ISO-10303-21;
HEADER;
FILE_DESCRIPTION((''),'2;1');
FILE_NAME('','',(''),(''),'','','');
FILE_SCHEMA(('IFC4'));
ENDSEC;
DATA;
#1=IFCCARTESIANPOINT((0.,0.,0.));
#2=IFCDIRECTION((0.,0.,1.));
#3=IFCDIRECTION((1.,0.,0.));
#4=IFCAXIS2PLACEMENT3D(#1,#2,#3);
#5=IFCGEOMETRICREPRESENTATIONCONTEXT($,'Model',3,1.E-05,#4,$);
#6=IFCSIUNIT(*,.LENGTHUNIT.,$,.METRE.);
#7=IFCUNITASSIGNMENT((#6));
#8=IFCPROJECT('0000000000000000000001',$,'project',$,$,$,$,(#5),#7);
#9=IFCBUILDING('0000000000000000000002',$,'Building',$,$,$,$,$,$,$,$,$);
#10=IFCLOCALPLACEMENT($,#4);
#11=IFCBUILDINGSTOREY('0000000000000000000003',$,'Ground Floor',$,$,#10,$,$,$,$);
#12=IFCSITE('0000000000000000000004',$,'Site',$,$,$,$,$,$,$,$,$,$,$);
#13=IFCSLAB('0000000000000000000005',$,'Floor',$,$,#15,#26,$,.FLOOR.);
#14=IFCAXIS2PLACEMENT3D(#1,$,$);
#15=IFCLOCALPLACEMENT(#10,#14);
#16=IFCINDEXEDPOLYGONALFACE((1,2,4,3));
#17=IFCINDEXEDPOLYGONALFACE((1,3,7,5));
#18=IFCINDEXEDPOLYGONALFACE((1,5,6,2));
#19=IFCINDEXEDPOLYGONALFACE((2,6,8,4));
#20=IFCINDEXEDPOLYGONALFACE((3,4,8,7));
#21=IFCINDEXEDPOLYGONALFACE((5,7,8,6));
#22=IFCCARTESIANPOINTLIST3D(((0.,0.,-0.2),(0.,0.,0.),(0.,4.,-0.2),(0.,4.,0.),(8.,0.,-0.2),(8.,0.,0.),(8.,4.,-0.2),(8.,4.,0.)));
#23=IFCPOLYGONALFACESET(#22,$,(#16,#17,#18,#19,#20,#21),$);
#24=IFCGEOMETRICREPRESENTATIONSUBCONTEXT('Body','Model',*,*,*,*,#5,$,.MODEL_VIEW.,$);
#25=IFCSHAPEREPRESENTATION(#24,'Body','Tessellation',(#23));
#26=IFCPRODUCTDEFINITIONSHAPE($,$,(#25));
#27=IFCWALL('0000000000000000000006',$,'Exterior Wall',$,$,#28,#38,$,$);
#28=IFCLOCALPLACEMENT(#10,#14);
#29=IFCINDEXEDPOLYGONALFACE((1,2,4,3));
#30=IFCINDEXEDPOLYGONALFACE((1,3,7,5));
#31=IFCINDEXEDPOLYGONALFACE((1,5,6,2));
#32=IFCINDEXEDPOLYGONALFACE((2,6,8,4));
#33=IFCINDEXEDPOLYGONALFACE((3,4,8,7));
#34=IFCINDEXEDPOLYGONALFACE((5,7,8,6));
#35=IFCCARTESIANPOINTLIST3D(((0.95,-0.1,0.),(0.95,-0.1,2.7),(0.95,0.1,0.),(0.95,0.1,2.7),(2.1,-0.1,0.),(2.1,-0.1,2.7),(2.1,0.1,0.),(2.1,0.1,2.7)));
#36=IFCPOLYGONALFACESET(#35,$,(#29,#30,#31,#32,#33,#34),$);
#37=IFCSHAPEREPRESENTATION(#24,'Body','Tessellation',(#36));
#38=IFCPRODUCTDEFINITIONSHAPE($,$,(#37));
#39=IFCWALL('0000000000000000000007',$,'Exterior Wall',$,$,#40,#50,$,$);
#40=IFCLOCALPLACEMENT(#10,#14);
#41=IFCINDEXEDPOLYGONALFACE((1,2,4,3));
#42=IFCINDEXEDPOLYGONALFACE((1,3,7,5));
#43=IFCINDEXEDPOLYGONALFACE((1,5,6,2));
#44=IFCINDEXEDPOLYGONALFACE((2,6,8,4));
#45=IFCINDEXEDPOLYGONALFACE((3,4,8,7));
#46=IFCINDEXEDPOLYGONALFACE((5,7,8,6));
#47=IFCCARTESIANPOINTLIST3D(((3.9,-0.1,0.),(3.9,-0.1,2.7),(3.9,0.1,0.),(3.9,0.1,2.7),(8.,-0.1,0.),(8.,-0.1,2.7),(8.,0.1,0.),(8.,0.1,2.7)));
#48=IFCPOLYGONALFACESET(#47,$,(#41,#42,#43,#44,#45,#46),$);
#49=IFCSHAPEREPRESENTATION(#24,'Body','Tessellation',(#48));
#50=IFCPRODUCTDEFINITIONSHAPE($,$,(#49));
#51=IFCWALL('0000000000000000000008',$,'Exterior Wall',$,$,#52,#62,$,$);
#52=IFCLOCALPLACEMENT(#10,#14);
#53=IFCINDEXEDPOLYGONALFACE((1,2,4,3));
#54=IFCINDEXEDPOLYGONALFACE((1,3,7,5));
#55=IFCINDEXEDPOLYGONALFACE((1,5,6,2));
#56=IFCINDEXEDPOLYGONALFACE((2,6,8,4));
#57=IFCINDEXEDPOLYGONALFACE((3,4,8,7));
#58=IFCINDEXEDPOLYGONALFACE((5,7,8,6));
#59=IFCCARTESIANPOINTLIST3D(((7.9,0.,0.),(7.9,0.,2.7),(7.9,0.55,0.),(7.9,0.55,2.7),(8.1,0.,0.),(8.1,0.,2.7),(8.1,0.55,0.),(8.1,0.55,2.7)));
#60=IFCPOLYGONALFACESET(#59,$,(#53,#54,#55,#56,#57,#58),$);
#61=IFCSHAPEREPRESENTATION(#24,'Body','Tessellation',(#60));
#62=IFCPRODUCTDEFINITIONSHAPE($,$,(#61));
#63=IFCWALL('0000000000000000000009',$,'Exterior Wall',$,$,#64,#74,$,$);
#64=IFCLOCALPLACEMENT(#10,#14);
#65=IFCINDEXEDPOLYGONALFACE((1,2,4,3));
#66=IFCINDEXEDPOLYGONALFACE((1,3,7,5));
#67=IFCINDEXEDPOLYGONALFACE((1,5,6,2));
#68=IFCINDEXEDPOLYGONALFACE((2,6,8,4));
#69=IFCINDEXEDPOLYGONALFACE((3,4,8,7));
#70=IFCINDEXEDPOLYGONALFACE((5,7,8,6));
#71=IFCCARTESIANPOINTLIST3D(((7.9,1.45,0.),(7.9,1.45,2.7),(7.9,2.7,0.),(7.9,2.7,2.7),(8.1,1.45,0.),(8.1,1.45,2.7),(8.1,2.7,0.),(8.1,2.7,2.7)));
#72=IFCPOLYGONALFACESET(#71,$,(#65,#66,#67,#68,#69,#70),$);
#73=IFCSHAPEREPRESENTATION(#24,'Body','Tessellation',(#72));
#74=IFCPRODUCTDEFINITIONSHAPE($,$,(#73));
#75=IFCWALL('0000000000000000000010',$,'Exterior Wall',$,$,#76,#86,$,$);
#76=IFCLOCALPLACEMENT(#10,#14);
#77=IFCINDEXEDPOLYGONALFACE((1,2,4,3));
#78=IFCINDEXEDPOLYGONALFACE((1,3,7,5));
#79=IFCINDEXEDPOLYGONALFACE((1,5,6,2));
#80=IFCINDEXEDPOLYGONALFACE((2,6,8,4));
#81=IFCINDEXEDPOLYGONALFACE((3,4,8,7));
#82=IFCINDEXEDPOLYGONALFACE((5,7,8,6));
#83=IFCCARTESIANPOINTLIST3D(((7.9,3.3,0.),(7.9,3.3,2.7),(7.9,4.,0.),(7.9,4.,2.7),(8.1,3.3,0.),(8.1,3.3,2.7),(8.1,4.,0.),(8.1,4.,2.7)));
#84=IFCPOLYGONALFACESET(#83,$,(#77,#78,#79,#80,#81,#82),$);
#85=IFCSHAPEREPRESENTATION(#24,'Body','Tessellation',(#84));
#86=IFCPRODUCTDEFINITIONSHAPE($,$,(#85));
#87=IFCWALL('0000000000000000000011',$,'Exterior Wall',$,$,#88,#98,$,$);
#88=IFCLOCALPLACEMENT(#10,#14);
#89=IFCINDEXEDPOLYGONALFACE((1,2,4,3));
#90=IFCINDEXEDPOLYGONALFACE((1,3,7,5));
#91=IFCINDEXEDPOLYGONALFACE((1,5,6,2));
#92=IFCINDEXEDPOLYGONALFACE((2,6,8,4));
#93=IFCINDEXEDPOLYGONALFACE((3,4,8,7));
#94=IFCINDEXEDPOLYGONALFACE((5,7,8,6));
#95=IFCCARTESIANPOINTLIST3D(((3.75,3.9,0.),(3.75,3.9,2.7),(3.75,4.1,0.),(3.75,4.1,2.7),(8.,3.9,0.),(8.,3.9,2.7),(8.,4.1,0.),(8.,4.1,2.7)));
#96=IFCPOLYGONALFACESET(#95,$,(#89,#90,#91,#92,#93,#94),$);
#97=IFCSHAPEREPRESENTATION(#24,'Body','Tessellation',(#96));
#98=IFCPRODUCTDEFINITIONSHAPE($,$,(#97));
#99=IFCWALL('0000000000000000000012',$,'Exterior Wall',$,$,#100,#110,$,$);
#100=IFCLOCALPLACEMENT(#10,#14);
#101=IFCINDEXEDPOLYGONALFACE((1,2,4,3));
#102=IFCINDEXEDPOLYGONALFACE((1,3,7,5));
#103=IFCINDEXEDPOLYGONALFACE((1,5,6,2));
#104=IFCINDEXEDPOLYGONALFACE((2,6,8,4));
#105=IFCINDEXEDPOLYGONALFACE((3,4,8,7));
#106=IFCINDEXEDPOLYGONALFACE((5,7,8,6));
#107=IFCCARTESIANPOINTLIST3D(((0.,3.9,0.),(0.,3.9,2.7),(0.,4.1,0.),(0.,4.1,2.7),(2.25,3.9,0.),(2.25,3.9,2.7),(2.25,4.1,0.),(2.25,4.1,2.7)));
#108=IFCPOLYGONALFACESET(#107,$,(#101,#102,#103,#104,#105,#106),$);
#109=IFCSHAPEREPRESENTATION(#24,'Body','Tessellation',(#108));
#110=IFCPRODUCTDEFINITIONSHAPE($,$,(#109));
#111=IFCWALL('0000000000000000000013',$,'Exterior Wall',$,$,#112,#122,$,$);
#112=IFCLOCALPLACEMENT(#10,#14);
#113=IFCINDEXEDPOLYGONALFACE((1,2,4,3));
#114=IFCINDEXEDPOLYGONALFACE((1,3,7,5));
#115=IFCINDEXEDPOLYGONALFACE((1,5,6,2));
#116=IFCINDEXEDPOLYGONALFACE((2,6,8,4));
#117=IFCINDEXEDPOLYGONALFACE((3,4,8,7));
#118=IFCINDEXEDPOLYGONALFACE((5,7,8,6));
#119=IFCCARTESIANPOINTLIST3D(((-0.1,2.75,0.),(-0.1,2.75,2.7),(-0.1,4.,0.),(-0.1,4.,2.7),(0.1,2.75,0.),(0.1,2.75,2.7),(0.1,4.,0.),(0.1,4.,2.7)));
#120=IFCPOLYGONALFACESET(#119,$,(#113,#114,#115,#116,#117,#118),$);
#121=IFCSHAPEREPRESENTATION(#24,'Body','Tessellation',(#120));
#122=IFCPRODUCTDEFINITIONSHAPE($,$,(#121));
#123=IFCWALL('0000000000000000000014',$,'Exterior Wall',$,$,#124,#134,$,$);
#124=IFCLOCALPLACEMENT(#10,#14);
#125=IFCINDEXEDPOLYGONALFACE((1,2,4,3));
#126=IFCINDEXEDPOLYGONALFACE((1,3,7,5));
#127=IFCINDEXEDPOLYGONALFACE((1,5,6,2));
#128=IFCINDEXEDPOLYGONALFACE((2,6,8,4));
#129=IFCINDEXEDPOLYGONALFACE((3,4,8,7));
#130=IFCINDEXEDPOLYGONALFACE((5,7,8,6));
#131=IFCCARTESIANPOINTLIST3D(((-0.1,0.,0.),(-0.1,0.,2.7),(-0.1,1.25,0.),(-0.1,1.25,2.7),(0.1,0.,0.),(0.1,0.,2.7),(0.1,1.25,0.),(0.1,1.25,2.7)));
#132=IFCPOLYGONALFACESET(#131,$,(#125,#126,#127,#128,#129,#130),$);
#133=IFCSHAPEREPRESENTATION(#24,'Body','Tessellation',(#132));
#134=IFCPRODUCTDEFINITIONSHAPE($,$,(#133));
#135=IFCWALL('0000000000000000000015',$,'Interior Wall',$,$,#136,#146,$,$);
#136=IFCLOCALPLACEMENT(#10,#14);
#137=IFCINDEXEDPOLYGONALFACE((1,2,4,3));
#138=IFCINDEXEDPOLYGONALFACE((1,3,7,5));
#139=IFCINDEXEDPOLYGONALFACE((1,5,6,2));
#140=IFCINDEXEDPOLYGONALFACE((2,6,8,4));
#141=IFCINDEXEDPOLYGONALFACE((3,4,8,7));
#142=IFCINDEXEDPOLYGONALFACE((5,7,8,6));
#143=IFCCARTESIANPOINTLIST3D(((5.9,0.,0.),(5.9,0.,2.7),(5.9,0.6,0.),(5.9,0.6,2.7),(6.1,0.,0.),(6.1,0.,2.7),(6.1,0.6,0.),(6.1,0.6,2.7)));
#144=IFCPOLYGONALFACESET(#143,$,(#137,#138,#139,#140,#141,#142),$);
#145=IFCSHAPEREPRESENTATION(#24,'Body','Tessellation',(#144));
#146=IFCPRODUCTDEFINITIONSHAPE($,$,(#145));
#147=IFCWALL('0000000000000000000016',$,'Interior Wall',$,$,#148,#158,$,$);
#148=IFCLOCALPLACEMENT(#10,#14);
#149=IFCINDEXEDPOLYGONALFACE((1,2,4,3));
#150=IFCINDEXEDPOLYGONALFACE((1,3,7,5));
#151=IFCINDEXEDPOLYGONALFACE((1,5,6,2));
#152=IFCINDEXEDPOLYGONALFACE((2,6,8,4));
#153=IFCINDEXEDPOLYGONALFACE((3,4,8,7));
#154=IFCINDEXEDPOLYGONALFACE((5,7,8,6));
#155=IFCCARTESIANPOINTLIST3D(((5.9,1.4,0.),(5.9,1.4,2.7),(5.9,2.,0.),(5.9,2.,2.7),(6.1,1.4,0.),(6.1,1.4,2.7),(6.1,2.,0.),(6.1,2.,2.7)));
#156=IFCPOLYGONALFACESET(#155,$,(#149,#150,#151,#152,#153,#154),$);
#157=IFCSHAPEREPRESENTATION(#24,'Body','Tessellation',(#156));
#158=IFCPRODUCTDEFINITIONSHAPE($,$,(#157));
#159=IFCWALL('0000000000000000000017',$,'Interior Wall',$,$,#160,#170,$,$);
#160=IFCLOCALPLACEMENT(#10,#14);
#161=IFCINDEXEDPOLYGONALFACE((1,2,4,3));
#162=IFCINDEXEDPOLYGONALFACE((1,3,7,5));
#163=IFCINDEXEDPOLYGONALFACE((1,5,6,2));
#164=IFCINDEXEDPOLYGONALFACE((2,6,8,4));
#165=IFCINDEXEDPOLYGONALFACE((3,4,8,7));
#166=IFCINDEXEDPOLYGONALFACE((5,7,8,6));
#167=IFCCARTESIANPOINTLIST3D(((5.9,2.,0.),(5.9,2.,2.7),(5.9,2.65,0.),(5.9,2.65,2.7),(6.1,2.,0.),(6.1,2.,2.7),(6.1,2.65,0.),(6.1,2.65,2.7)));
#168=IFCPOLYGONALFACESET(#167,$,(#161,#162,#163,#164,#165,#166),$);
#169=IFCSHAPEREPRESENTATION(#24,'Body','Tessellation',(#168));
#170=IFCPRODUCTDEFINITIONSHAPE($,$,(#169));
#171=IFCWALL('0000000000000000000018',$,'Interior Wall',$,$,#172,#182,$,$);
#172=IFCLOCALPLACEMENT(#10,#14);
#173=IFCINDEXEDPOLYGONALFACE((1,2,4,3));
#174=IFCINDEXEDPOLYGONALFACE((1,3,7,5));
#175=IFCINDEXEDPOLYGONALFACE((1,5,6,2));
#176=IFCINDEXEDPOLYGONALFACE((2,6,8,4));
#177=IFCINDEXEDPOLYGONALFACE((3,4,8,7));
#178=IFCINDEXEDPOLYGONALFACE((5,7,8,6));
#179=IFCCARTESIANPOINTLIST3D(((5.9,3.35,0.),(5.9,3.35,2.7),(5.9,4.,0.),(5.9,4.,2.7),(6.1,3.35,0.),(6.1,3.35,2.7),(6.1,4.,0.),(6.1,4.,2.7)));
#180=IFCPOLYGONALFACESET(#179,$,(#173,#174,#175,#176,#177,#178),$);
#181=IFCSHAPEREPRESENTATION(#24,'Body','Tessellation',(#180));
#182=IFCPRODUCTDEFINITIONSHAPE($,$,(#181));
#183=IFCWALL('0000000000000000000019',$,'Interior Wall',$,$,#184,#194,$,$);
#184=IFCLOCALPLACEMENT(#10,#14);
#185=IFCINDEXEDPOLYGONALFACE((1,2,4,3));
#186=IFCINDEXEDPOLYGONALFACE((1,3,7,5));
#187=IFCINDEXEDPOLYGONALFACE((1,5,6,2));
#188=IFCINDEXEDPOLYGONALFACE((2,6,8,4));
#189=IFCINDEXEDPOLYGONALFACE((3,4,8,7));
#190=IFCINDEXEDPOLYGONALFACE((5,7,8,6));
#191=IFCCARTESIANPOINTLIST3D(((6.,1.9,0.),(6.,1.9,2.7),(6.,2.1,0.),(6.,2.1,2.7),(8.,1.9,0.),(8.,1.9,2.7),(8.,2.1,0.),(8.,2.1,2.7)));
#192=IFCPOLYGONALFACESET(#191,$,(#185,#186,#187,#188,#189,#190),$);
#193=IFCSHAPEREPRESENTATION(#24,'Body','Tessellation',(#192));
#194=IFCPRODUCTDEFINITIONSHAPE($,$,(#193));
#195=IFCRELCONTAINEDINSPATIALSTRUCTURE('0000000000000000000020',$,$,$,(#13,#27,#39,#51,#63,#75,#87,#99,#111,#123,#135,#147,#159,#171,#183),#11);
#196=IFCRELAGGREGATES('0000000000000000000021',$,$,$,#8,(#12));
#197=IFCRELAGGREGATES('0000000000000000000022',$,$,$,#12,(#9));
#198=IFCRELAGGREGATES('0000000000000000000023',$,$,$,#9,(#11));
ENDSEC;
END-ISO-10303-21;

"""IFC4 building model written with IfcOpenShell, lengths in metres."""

from ifc_helpers import new_model, si_unit, frame, origin_with_axes, place, context, subcontext, project, spatial, indexed_curve, outline, extrude, element, save


model = new_model("IFC4")

# Units and contexts
model_context = context("Model", 3, precision=1e-05, world=origin_with_axes())
body_context = subcontext(model_context, "Body", "Model", "MODEL_VIEW")
ifc_project = project(units=[si_unit("LENGTHUNIT", "METRE")], contexts=[model_context])

# Site, building, storey
site = spatial("IfcSite", under=ifc_project, Name="Site")
building = spatial("IfcBuilding", under=site, Name="Building")
storey_placement = place(None, origin_with_axes())
storey = spatial("IfcBuildingStorey", under=building, at=storey_placement, Name="Ground Floor")

# Slab
slab_placement = place(storey_placement, frame((0.0, 0.0, -0.2), z_axis=(0.0, 0.0, 1.0), x_axis=(1.0, 0.0, 0.0)))
element("IfcSlab", 1, at=slab_placement, inside=storey, Name="Floor", PredefinedType="FLOOR", context=body_context, shape_type="SweptSolid", body=[
    extrude(outline(indexed_curve([(0.0, 0.0), (8.0, 0.0), (8.0, 4.0), (0.0, 4.0)])), None, (0.0, 0.0, 1.0), 0.2),
])

# Walls
wall_1_placement = place(storey_placement, frame((0.95, 0.0, 0.0), z_axis=(0.0, 0.0, 1.0), x_axis=(1.0, 0.0, 0.0)))
element("IfcWall", 2, at=wall_1_placement, inside=storey, Name="Exterior Wall", context=body_context, shape_type="SweptSolid", body=[
    extrude(outline(indexed_curve([(0.0, 0.0), (0.0, 0.2), (1.15, 0.2), (1.15, 0.0), (0.0, 0.0)], self_intersect=False)), frame((0.0, -0.1, 0.0), z_axis=(0.0, 0.0, 1.0), x_axis=(1.0, 0.0, 0.0)), (0.0, 0.0, 1.0), 2.7),
])
wall_2_placement = place(storey_placement, frame((3.9, 0.0, 0.0), z_axis=(0.0, 0.0, 1.0), x_axis=(1.0, 0.0, 0.0)))
element("IfcWall", 3, at=wall_2_placement, inside=storey, Name="Exterior Wall", context=body_context, shape_type="SweptSolid", body=[
    extrude(outline(indexed_curve([(0.0, 0.0), (0.0, 0.2), (4.1, 0.2), (4.1, 0.0), (0.0, 0.0)], self_intersect=False)), frame((0.0, -0.1, 0.0), z_axis=(0.0, 0.0, 1.0), x_axis=(1.0, 0.0, 0.0)), (0.0, 0.0, 1.0), 2.7),
])
wall_3_placement = place(storey_placement, frame((8.0, 0.0, 0.0), z_axis=(0.0, 0.0, 1.0), x_axis=(0.0, 1.0, 0.0)))
element("IfcWall", 4, at=wall_3_placement, inside=storey, Name="Exterior Wall", context=body_context, shape_type="SweptSolid", body=[
    extrude(outline(indexed_curve([(0.0, 0.0), (0.0, 0.2), (0.55, 0.2), (0.55, 0.0), (0.0, 0.0)], self_intersect=False)), frame((0.0, -0.1, 0.0), z_axis=(0.0, 0.0, 1.0), x_axis=(1.0, 0.0, 0.0)), (0.0, 0.0, 1.0), 2.7),
])
wall_4_placement = place(storey_placement, frame((8.0, 1.45, 0.0), z_axis=(0.0, 0.0, 1.0), x_axis=(0.0, 1.0, 0.0)))
element("IfcWall", 5, at=wall_4_placement, inside=storey, Name="Exterior Wall", context=body_context, shape_type="SweptSolid", body=[
    extrude(outline(indexed_curve([(0.0, 0.0), (0.0, 0.2), (1.25, 0.2), (1.25, 0.0), (0.0, 0.0)], self_intersect=False)), frame((0.0, -0.1, 0.0), z_axis=(0.0, 0.0, 1.0), x_axis=(1.0, 0.0, 0.0)), (0.0, 0.0, 1.0), 2.7),
])
wall_5_placement = place(storey_placement, frame((8.0, 3.3, 0.0), z_axis=(0.0, 0.0, 1.0), x_axis=(0.0, 1.0, 0.0)))
element("IfcWall", 6, at=wall_5_placement, inside=storey, Name="Exterior Wall", context=body_context, shape_type="SweptSolid", body=[
    extrude(outline(indexed_curve([(0.0, 0.0), (0.0, 0.2), (0.7, 0.2), (0.7, 0.0), (0.0, 0.0)], self_intersect=False)), frame((0.0, -0.1, 0.0), z_axis=(0.0, 0.0, 1.0), x_axis=(1.0, 0.0, 0.0)), (0.0, 0.0, 1.0), 2.7),
])
wall_6_placement = place(storey_placement, frame((8.0, 4.0, 0.0), z_axis=(0.0, 0.0, 1.0), x_axis=(-1.0, 0.0, 0.0)))
element("IfcWall", 7, at=wall_6_placement, inside=storey, Name="Exterior Wall", context=body_context, shape_type="SweptSolid", body=[
    extrude(outline(indexed_curve([(0.0, 0.0), (0.0, 0.2), (4.25, 0.2), (4.25, 0.0), (0.0, 0.0)], self_intersect=False)), frame((0.0, -0.1, 0.0), z_axis=(0.0, 0.0, 1.0), x_axis=(1.0, 0.0, 0.0)), (0.0, 0.0, 1.0), 2.7),
])
wall_7_placement = place(storey_placement, frame((2.25, 4.0, 0.0), z_axis=(0.0, 0.0, 1.0), x_axis=(-1.0, 0.0, 0.0)))
element("IfcWall", 8, at=wall_7_placement, inside=storey, Name="Exterior Wall", context=body_context, shape_type="SweptSolid", body=[
    extrude(outline(indexed_curve([(0.0, 0.0), (0.0, 0.2), (2.25, 0.2), (2.25, 0.0), (0.0, 0.0)], self_intersect=False)), frame((0.0, -0.1, 0.0), z_axis=(0.0, 0.0, 1.0), x_axis=(1.0, 0.0, 0.0)), (0.0, 0.0, 1.0), 2.7),
])
for number, where, z_axis, x_axis, name in (
    (9, (0.0, 4.0, 0.0), (0.0, 0.0, 1.0), (0.0, -1.0, 0.0), "Exterior Wall"),
    (10, (0.0, 1.25, 0.0), (0.0, 0.0, 1.0), (0.0, -1.0, 0.0), "Exterior Wall"),
):
    element("IfcWall", number, at=place(storey_placement, frame(where, z_axis=z_axis, x_axis=x_axis)), inside=storey, Name=name, context=body_context, shape_type="SweptSolid", body=[
        extrude(outline(indexed_curve([(0.0, 0.0), (0.0, 0.2), (1.25, 0.2), (1.25, 0.0), (0.0, 0.0)], self_intersect=False)), frame((0.0, -0.1, 0.0), z_axis=(0.0, 0.0, 1.0), x_axis=(1.0, 0.0, 0.0)), (0.0, 0.0, 1.0), 2.7),
    ])
wall_8_placement = place(storey_placement, frame((6.0, 0.0, 0.0), z_axis=(0.0, 0.0, 1.0), x_axis=(0.0, 1.0, 0.0)))
element("IfcWall", 11, at=wall_8_placement, inside=storey, Name="Interior Wall", context=body_context, shape_type="SweptSolid", body=[
    extrude(outline(indexed_curve([(0.0, 0.0), (0.0, 0.2), (0.6, 0.2), (0.6, 0.0), (0.0, 0.0)], self_intersect=False)), frame((0.0, -0.1, 0.0), z_axis=(0.0, 0.0, 1.0), x_axis=(1.0, 0.0, 0.0)), (0.0, 0.0, 1.0), 2.7),
])
wall_9_placement = place(storey_placement, frame((6.0, 1.4, 0.0), z_axis=(0.0, 0.0, 1.0), x_axis=(0.0, 1.0, 0.0)))
element("IfcWall", 12, at=wall_9_placement, inside=storey, Name="Interior Wall", context=body_context, shape_type="SweptSolid", body=[
    extrude(outline(indexed_curve([(0.0, 0.0), (0.0, 0.2), (0.6, 0.2), (0.6, 0.0), (0.0, 0.0)], self_intersect=False)), frame((0.0, -0.1, 0.0), z_axis=(0.0, 0.0, 1.0), x_axis=(1.0, 0.0, 0.0)), (0.0, 0.0, 1.0), 2.7),
])
for number, where, z_axis, x_axis, name in (
    (13, (6.0, 2.0, 0.0), (0.0, 0.0, 1.0), (0.0, 1.0, 0.0), "Interior Wall"),
    (14, (6.0, 3.35, 0.0), (0.0, 0.0, 1.0), (0.0, 1.0, 0.0), "Interior Wall"),
):
    element("IfcWall", number, at=place(storey_placement, frame(where, z_axis=z_axis, x_axis=x_axis)), inside=storey, Name=name, context=body_context, shape_type="SweptSolid", body=[
        extrude(outline(indexed_curve([(0.0, 0.0), (0.0, 0.2), (0.65, 0.2), (0.65, 0.0), (0.0, 0.0)], self_intersect=False)), frame((0.0, -0.1, 0.0), z_axis=(0.0, 0.0, 1.0), x_axis=(1.0, 0.0, 0.0)), (0.0, 0.0, 1.0), 2.7),
    ])
wall_10_placement = place(storey_placement, frame((8.0, 2.0, 0.0), z_axis=(0.0, 0.0, 1.0), x_axis=(-1.0, 0.0, 0.0)))
element("IfcWall", 15, at=wall_10_placement, inside=storey, Name="Interior Wall", context=body_context, shape_type="SweptSolid", body=[
    extrude(outline(indexed_curve([(0.0, 0.0), (0.0, 0.2), (2.0, 0.2), (2.0, 0.0), (0.0, 0.0)], self_intersect=False)), frame((0.0, -0.1, 0.0), z_axis=(0.0, 0.0, 1.0), x_axis=(1.0, 0.0, 0.0)), (0.0, 0.0, 1.0), 2.7),
])

save(model, "model.ifc")
